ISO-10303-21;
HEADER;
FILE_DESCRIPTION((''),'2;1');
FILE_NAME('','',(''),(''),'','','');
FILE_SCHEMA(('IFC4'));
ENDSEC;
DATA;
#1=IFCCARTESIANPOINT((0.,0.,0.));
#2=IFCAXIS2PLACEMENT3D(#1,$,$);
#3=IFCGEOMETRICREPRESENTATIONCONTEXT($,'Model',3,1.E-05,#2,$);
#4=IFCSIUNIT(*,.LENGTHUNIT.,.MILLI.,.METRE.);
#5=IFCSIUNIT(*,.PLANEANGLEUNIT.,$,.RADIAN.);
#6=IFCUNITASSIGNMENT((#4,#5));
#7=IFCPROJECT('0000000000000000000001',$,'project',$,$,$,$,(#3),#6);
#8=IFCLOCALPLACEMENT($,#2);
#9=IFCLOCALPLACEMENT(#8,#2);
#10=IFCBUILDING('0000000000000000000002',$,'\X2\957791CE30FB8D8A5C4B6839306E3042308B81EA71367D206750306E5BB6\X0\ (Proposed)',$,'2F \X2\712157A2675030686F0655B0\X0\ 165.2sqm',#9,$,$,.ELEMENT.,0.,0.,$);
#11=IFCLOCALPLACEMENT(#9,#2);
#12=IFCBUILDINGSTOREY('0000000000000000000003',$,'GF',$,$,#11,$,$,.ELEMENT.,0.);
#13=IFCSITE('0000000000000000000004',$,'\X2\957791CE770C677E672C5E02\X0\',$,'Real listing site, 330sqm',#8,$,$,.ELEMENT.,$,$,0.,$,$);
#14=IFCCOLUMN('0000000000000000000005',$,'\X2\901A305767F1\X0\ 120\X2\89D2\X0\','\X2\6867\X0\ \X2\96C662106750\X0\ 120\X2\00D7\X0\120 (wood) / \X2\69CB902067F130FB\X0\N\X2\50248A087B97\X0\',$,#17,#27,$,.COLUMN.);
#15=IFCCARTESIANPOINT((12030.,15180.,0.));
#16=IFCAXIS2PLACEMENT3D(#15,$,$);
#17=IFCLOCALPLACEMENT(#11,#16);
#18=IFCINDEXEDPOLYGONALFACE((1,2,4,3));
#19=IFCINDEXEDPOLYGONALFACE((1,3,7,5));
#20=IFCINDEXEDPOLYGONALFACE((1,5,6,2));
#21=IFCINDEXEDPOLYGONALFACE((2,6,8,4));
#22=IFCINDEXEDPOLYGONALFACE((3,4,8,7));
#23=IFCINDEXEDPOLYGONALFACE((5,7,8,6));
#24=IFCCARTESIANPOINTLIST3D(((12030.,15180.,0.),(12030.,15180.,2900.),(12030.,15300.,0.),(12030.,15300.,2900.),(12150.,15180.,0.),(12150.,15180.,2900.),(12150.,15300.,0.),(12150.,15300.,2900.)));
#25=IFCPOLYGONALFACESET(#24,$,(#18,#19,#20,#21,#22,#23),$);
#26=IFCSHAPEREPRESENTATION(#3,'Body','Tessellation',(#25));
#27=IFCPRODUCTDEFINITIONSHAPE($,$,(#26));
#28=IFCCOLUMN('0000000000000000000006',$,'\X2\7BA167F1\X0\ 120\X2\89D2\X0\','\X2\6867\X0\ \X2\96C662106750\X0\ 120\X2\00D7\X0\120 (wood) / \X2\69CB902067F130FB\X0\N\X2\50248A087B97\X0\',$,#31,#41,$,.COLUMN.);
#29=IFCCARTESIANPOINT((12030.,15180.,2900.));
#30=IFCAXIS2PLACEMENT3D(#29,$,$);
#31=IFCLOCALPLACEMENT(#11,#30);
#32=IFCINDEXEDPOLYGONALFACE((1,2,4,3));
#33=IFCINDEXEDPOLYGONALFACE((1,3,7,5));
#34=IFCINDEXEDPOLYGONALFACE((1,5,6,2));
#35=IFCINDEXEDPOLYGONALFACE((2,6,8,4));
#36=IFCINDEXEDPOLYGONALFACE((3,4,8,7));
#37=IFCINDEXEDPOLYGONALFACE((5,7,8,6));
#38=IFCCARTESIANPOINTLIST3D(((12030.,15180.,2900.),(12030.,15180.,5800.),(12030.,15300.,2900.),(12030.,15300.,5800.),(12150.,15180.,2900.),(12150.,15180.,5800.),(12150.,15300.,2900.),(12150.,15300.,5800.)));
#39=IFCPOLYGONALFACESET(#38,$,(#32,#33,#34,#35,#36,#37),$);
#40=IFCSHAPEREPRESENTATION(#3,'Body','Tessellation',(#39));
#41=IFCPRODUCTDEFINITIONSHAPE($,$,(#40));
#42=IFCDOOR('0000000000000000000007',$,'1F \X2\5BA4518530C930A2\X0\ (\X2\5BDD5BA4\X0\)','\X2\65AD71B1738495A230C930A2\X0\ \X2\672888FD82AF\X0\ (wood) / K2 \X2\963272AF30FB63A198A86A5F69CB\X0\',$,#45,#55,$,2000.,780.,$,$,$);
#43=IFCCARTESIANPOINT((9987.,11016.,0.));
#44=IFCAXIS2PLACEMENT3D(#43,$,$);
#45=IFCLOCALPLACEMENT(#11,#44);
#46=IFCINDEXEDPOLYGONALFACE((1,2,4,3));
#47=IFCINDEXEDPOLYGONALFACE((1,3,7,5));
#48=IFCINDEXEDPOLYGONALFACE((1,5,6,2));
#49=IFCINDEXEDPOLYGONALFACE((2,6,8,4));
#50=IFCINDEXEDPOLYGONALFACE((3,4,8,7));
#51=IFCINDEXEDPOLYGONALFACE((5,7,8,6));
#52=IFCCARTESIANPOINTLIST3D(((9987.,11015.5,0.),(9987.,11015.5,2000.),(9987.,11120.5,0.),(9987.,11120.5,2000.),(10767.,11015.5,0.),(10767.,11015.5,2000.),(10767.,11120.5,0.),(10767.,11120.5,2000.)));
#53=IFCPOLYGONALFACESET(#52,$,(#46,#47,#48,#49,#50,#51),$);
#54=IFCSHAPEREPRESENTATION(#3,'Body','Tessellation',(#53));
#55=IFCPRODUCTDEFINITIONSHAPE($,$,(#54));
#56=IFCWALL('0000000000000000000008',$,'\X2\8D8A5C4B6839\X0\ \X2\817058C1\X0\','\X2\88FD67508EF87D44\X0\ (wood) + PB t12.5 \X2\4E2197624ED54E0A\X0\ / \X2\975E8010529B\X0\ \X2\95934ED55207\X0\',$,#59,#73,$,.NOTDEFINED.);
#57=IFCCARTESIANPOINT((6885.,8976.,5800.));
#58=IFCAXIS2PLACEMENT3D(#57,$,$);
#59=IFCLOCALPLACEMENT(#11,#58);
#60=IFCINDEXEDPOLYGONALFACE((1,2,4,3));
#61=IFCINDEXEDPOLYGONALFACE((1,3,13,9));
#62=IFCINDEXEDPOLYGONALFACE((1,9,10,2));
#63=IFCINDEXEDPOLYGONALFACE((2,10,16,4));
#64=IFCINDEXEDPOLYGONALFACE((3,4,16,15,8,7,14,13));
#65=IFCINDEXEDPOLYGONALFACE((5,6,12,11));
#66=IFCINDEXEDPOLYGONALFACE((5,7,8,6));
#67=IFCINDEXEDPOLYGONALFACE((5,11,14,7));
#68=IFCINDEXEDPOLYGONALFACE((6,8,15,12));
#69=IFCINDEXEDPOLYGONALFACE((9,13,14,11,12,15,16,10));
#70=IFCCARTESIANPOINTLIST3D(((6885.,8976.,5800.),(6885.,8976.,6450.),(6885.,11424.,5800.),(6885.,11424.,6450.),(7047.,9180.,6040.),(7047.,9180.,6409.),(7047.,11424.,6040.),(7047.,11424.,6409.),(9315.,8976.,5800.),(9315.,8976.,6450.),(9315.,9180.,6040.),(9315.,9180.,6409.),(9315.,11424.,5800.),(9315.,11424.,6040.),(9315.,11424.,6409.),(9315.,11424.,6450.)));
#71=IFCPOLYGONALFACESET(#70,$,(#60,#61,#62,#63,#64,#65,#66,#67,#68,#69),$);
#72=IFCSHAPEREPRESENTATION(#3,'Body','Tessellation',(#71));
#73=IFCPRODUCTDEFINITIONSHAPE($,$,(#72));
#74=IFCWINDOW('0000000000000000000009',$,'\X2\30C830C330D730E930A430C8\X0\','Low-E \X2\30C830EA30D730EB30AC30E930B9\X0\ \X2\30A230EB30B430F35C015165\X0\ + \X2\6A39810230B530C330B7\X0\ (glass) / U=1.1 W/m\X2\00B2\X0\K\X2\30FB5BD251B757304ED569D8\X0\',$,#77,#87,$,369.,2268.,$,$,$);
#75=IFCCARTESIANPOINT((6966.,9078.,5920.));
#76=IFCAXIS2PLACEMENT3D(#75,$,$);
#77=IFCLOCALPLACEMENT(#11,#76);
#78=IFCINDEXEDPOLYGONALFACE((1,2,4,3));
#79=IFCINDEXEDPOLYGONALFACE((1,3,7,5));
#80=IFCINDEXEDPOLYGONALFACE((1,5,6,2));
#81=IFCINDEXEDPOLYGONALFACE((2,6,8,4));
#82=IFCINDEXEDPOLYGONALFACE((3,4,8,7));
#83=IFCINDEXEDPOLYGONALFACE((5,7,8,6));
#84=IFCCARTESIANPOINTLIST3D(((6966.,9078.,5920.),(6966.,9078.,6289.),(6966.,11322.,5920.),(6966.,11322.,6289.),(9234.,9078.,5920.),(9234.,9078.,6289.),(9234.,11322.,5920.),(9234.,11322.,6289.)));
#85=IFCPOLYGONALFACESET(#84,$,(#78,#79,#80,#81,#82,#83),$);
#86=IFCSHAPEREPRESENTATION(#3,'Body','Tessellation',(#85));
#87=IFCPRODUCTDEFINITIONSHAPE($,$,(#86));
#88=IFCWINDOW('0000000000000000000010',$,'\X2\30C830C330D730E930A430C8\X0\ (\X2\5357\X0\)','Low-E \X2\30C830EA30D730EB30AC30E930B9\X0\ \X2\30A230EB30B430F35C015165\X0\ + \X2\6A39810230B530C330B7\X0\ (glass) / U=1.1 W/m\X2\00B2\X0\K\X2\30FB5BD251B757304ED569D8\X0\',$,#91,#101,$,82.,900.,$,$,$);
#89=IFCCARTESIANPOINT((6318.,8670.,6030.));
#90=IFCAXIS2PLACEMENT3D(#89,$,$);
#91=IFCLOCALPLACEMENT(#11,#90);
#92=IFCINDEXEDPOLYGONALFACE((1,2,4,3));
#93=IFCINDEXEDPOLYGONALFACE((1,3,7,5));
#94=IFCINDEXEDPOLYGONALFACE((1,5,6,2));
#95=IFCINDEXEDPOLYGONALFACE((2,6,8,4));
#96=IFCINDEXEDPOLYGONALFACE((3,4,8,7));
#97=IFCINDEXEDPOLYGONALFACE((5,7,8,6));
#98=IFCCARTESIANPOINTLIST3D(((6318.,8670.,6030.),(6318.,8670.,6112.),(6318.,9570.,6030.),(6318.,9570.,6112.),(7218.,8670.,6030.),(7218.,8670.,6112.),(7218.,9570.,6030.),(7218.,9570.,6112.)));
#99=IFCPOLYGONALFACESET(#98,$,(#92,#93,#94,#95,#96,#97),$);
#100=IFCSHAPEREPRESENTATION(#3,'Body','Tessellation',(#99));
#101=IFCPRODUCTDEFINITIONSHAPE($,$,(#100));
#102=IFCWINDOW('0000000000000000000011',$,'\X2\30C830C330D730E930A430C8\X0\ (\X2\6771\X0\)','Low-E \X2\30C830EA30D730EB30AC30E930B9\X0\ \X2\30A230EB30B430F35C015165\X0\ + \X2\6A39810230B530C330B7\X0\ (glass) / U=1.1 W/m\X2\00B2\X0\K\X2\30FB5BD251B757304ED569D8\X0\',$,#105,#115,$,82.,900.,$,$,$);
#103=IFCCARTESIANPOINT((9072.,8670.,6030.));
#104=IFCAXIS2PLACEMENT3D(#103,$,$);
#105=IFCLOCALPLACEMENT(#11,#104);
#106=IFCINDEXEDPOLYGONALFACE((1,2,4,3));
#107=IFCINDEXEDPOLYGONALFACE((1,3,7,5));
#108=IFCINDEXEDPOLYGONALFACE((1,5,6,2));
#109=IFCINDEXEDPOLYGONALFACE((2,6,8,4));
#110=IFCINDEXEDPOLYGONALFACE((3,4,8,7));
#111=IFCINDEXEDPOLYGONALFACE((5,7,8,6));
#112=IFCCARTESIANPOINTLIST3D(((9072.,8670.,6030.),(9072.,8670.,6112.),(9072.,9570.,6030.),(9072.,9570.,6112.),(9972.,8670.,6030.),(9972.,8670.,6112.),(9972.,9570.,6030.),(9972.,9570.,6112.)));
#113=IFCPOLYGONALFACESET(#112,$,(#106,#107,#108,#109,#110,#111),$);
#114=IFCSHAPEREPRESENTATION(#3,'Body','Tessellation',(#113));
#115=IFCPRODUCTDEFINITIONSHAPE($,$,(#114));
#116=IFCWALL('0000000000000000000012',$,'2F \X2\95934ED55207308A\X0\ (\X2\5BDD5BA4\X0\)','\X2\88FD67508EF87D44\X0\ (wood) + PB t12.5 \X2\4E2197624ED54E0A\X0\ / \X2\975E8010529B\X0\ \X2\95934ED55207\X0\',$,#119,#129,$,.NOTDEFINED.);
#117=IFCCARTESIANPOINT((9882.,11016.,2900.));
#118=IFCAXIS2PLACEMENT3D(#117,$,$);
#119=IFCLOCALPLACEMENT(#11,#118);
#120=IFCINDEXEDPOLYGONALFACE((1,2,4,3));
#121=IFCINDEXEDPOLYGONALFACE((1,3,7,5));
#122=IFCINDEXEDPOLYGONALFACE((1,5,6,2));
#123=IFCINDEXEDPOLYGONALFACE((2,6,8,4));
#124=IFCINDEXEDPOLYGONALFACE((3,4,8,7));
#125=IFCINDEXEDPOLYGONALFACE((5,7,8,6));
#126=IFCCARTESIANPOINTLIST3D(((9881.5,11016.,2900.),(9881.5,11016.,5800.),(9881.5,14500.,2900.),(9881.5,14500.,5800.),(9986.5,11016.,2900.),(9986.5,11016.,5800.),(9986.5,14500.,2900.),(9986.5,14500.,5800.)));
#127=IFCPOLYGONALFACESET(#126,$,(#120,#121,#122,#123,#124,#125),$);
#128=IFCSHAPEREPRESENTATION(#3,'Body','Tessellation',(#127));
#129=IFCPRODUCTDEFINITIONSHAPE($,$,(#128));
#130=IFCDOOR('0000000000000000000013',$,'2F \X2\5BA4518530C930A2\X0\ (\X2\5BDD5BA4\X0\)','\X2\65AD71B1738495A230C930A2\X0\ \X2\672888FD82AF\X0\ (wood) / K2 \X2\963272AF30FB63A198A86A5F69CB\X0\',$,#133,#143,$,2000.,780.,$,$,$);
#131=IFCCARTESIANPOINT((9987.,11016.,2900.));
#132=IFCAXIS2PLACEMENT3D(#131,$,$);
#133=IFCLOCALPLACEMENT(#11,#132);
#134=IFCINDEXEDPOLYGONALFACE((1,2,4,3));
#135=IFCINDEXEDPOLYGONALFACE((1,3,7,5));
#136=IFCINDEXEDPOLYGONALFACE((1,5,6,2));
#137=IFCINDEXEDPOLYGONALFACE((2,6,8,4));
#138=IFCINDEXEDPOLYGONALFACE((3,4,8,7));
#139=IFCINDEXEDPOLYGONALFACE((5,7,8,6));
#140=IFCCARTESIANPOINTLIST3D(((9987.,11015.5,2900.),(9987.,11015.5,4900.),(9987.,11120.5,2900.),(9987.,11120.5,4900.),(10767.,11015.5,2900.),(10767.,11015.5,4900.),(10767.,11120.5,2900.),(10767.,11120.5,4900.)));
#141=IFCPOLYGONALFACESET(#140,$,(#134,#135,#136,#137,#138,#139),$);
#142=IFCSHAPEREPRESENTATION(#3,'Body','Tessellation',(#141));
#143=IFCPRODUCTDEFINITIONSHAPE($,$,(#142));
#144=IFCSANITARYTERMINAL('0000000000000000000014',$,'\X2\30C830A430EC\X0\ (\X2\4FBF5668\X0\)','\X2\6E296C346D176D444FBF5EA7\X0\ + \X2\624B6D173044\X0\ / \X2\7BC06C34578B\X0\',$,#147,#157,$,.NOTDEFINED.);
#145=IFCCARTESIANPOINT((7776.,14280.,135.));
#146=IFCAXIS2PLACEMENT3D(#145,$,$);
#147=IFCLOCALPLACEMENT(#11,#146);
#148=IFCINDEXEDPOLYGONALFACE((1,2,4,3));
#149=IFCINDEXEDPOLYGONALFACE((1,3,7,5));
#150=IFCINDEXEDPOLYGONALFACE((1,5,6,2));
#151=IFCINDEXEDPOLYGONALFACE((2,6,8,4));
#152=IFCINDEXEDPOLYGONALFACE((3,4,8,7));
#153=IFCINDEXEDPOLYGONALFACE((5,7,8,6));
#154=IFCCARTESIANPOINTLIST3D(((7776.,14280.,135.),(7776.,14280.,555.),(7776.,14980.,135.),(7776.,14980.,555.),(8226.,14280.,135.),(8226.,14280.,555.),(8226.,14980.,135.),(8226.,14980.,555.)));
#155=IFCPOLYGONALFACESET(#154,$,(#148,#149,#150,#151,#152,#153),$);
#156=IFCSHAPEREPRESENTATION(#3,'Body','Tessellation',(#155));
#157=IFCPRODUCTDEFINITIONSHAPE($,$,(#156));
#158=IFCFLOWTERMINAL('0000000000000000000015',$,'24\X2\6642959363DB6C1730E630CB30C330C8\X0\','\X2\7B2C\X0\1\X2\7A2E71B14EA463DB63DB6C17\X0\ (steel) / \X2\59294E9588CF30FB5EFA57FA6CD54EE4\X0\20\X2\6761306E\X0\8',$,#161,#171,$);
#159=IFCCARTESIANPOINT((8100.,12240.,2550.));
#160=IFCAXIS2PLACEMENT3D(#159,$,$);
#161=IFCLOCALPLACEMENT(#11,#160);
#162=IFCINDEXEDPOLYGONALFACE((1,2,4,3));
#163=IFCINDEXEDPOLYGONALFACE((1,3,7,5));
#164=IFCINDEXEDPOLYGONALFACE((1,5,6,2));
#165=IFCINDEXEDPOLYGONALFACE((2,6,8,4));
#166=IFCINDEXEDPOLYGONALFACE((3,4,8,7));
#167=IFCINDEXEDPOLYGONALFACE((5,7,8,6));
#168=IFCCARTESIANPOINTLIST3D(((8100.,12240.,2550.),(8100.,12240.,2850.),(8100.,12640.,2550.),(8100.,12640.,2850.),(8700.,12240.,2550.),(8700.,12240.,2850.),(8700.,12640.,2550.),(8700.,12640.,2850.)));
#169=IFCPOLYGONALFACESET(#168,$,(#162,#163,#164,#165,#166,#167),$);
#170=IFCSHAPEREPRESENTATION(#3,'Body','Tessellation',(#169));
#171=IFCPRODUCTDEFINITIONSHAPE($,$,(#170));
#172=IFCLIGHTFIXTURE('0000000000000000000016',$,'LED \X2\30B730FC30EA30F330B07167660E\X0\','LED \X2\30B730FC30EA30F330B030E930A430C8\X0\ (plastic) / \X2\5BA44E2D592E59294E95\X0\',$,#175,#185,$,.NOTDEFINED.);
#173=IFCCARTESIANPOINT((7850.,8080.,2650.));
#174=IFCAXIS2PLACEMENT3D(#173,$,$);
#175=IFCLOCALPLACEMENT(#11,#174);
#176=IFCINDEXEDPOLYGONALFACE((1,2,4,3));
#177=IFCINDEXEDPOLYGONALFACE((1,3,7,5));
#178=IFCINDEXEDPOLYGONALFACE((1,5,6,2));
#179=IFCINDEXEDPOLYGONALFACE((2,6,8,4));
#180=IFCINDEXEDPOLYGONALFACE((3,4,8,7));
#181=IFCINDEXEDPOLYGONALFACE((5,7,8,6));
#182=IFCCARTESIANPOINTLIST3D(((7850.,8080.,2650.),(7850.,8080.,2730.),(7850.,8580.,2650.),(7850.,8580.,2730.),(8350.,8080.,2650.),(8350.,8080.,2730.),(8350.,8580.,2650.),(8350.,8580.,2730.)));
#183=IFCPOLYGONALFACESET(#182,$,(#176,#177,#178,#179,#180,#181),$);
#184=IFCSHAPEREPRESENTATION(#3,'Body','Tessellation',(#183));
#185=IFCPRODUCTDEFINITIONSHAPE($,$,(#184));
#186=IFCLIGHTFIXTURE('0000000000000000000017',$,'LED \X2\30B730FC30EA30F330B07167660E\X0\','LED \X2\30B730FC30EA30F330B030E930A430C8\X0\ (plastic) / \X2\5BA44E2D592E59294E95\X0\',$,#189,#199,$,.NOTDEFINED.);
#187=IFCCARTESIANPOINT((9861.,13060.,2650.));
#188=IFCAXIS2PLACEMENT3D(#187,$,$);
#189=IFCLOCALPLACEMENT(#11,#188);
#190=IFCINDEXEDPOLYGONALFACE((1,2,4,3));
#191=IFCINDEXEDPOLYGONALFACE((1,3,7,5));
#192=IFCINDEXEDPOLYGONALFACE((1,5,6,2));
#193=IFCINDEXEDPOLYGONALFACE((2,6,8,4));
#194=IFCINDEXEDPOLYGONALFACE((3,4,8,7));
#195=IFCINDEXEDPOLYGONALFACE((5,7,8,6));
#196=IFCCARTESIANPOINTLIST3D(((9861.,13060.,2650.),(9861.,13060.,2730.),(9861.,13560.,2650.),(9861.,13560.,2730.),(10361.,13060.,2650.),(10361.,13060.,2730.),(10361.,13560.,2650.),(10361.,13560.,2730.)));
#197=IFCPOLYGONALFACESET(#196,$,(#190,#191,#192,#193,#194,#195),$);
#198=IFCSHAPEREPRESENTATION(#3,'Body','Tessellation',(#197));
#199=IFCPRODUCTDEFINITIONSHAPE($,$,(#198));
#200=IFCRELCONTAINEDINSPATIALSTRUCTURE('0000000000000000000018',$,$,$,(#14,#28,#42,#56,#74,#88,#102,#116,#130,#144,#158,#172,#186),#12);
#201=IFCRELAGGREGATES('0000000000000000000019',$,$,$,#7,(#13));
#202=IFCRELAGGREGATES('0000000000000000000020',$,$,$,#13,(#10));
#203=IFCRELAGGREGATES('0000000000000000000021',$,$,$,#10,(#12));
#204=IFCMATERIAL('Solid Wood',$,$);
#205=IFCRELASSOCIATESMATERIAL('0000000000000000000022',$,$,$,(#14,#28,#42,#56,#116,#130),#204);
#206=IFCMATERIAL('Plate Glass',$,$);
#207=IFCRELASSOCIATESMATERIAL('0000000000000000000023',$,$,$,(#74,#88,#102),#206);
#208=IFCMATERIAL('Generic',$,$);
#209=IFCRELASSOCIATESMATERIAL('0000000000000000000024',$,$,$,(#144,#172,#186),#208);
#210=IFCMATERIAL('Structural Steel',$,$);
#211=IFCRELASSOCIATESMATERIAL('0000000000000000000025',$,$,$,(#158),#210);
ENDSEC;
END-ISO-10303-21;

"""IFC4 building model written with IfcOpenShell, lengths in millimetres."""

from ifc_helpers import new_model, si_unit, frame, frame_2d, origin, place, context, project, spatial, rectangle, extrude, material, element, fill, save


model = new_model("IFC4")

# Units and contexts
model_context = context("Model", 3, precision=1e-05, world=origin())
ifc_project = project(units=[si_unit("LENGTHUNIT", "METRE", prefix="MILLI"), si_unit("PLANEANGLEUNIT", "RADIAN")], contexts=[model_context])

# Site, building, storey
site_placement = place(None, origin())
site = spatial("IfcSite", under=ifc_project, at=site_placement, Name="長野県松本市", ObjectType="Real listing site, 330sqm", CompositionType="ELEMENT", RefElevation=0.0)
building_placement = place(site_placement, origin())
building = spatial("IfcBuilding", under=site, at=building_placement, Name="長野・越屋根のある自然素材の家 (Proposed)", ObjectType="2F 無垢材と漆喰 165.2sqm", CompositionType="ELEMENT", ElevationOfRefHeight=0.0, ElevationOfTerrain=0.0)
storey_placement = place(building_placement, origin())
storey = spatial("IfcBuildingStorey", under=building, at=storey_placement, Name="GF", CompositionType="ELEMENT", Elevation=0.0)

# Columns
ifc_material_1 = material(Name="Solid Wood")
column_1_placement = place(storey_placement, frame((12030.0, 15180.0, 0.0)))
element("IfcColumn", 1, at=column_1_placement, inside=storey, material=ifc_material_1, Name="通し柱 120角", Description="桧 集成材 120×120 (wood) / 構造柱・N値計算", PredefinedType="COLUMN", context=model_context, shape_type="SweptSolid", body=[
    extrude(rectangle(XDim=120.0, YDim=120.0, at=frame_2d((60.0, 60.0))), frame((12030.0, 15180.0, 0.0)), (0.0, 0.0, 1.0), 2900.0),
])
column_2_placement = place(storey_placement, frame((12030.0, 15180.0, 2900.0)))
element("IfcColumn", 2, at=column_2_placement, inside=storey, material=ifc_material_1, Name="管柱 120角", Description="桧 集成材 120×120 (wood) / 構造柱・N値計算", PredefinedType="COLUMN", context=model_context, shape_type="SweptSolid", body=[
    extrude(rectangle(XDim=120.0, YDim=120.0, at=frame_2d((60.0, 60.0))), frame((12030.0, 15180.0, 2900.0)), (0.0, 0.0, 1.0), 2900.0),
])

# Door
door_1_placement = place(storey_placement, frame((9987.0, 11016.0, 0.0)))
element("IfcDoor", 3, at=door_1_placement, inside=storey, material=ifc_material_1, Name="1F 室内ドア (寝室)", Description="断熱玄関ドア 木製芯 (wood) / K2 防犯・採風機構", OverallHeight=2000.0, OverallWidth=780.0, context=model_context, shape_type="SweptSolid", body=[
    extrude(rectangle(XDim=780.0, YDim=105.0, at=frame_2d((390.0, 52.0))), frame((9987.0, 11016.0, 0.0)), (0.0, 0.0, 1.0), 2000.0),
])

# Wall, openings, windows
wall_1_placement = place(storey_placement, frame((6885.0, 8976.0, 5800.0)))
wall_1 = element("IfcWall", 4, at=wall_1_placement, inside=storey, material=ifc_material_1, Name="越屋根 腰壁", Description="製材軸組 (wood) + PB t12.5 両面仕上 / 非耐力 間仕切", PredefinedType="NOTDEFINED", context=model_context, shape_type="SweptSolid", body=[
    extrude(rectangle(XDim=2430.0, YDim=2448.0, at=frame_2d((1215.0, 1224.0))), frame((6885.0, 8976.0, 5800.0)), (0.0, 0.0, 1.0), 650.0),
])
opening_1_placement = place(storey_placement, frame((6966.0, 9078.0, 5920.0)))
opening_1 = element("IfcOpeningElement", 5, at=opening_1_placement, cuts=wall_1, PredefinedType="NOTDEFINED", context=model_context, shape_type="SweptSolid", body=[
    extrude(rectangle(XDim=2268.0, YDim=2244.0, at=frame_2d((1134.0, 1122.0))), frame((6966.0, 9078.0, 5920.0)), (0.0, 0.0, 1.0), 369.0),
])
opening_2_placement = place(storey_placement, frame((6318.0, 8670.0, 6030.0)))
opening_2 = element("IfcOpeningElement", 6, at=opening_2_placement, cuts=wall_1, PredefinedType="NOTDEFINED", context=model_context, shape_type="SweptSolid", body=[
    extrude(rectangle(XDim=900.0, YDim=900.0, at=frame_2d((450.0, 450.0))), frame((6318.0, 8670.0, 6030.0)), (0.0, 0.0, 1.0), 82.0),
])
opening_3_placement = place(storey_placement, frame((9072.0, 8670.0, 6030.0)))
opening_3 = element("IfcOpeningElement", 7, at=opening_3_placement, cuts=wall_1, PredefinedType="NOTDEFINED", context=model_context, shape_type="SweptSolid", body=[
    extrude(rectangle(XDim=900.0, YDim=900.0, at=frame_2d((450.0, 450.0))), frame((9072.0, 8670.0, 6030.0)), (0.0, 0.0, 1.0), 82.0),
])
ifc_material_2 = material(Name="Plate Glass")
window_1_placement = place(storey_placement, frame((6966.0, 9078.0, 5920.0)))
window_1 = element("IfcWindow", 8, at=window_1_placement, inside=storey, material=ifc_material_2, Name="トップライト", Description="Low-E トリプルガラス アルゴン封入 + 樹脂サッシ (glass) / U=1.1 W/m²K・寒冷地仕様", OverallHeight=369.0, OverallWidth=2268.0, context=model_context, shape_type="SweptSolid", body=[
    extrude(rectangle(XDim=2268.0, YDim=2244.0, at=frame_2d((1134.0, 1122.0))), frame((6966.0, 9078.0, 5920.0)), (0.0, 0.0, 1.0), 369.0),
])
fill(opening_1, window_1)
window_2_placement = place(storey_placement, frame((6318.0, 8670.0, 6030.0)))
window_2 = element("IfcWindow", 9, at=window_2_placement, inside=storey, material=ifc_material_2, Name="トップライト (南)", Description="Low-E トリプルガラス アルゴン封入 + 樹脂サッシ (glass) / U=1.1 W/m²K・寒冷地仕様", OverallHeight=82.0, OverallWidth=900.0, context=model_context, shape_type="SweptSolid", body=[
    extrude(rectangle(XDim=900.0, YDim=900.0, at=frame_2d((450.0, 450.0))), frame((6318.0, 8670.0, 6030.0)), (0.0, 0.0, 1.0), 82.0),
])
fill(opening_2, window_2)
window_3_placement = place(storey_placement, frame((9072.0, 8670.0, 6030.0)))
window_3 = element("IfcWindow", 10, at=window_3_placement, inside=storey, material=ifc_material_2, Name="トップライト (東)", Description="Low-E トリプルガラス アルゴン封入 + 樹脂サッシ (glass) / U=1.1 W/m²K・寒冷地仕様", OverallHeight=82.0, OverallWidth=900.0, context=model_context, shape_type="SweptSolid", body=[
    extrude(rectangle(XDim=900.0, YDim=900.0, at=frame_2d((450.0, 450.0))), frame((9072.0, 8670.0, 6030.0)), (0.0, 0.0, 1.0), 82.0),
])
fill(opening_3, window_3)

# Wall
wall_2_placement = place(storey_placement, frame((9882.0, 11016.0, 2900.0)))
element("IfcWall", 11, at=wall_2_placement, inside=storey, material=ifc_material_1, Name="2F 間仕切り (寝室)", Description="製材軸組 (wood) + PB t12.5 両面仕上 / 非耐力 間仕切", PredefinedType="NOTDEFINED", context=model_context, shape_type="SweptSolid", body=[
    extrude(rectangle(XDim=105.0, YDim=3484.0, at=frame_2d((52.0, 1742.0))), frame((9882.0, 11016.0, 2900.0)), (0.0, 0.0, 1.0), 2900.0),
])

# Door
door_2_placement = place(storey_placement, frame((9987.0, 11016.0, 2900.0)))
element("IfcDoor", 12, at=door_2_placement, inside=storey, material=ifc_material_1, Name="2F 室内ドア (寝室)", Description="断熱玄関ドア 木製芯 (wood) / K2 防犯・採風機構", OverallHeight=2000.0, OverallWidth=780.0, context=model_context, shape_type="SweptSolid", body=[
    extrude(rectangle(XDim=780.0, YDim=105.0, at=frame_2d((390.0, 52.0))), frame((9987.0, 11016.0, 2900.0)), (0.0, 0.0, 1.0), 2000.0),
])

# Sanitary terminal
ifc_material_3 = material(Name="Generic")
sanitary_terminal_placement = place(storey_placement, frame((7776.0, 14280.0, 135.0)))
element("IfcSanitaryTerminal", 13, at=sanitary_terminal_placement, inside=storey, material=ifc_material_3, Name="トイレ (便器)", Description="温水洗浄便座 + 手洗い / 節水型", PredefinedType="NOTDEFINED", context=model_context, shape_type="SweptSolid", body=[
    extrude(rectangle(XDim=450.0, YDim=700.0, at=frame_2d((225.0, 350.0))), frame((7776.0, 14280.0, 135.0)), (0.0, 0.0, 1.0), 420.0),
])

# Flow terminal
ifc_material_4 = material(Name="Structural Steel")
flow_terminal_placement = place(storey_placement, frame((8100.0, 12240.0, 2550.0)))
element("IfcFlowTerminal", 14, at=flow_terminal_placement, inside=storey, material=ifc_material_4, Name="24時間換気ユニット", Description="第1種熱交換換気 (steel) / 天井裏・建基法令20条の8", context=model_context, shape_type="SweptSolid", body=[
    extrude(rectangle(XDim=600.0, YDim=400.0, at=frame_2d((300.0, 200.0))), frame((8100.0, 12240.0, 2550.0)), (0.0, 0.0, 1.0), 300.0),
])

# Light fixtures
light_fixture_1_placement = place(storey_placement, frame((7850.0, 8080.0, 2650.0)))
element("IfcLightFixture", 15, at=light_fixture_1_placement, inside=storey, material=ifc_material_3, Name="LED シーリング照明", Description="LED シーリングライト (plastic) / 室中央天井", PredefinedType="NOTDEFINED", context=model_context, shape_type="SweptSolid", body=[
    extrude(rectangle(XDim=500.0, YDim=500.0, at=frame_2d((250.0, 250.0))), frame((7850.0, 8080.0, 2650.0)), (0.0, 0.0, 1.0), 80.0),
])
light_fixture_2_placement = place(storey_placement, frame((9861.0, 13060.0, 2650.0)))
element("IfcLightFixture", 16, at=light_fixture_2_placement, inside=storey, material=ifc_material_3, Name="LED シーリング照明", Description="LED シーリングライト (plastic) / 室中央天井", PredefinedType="NOTDEFINED", context=model_context, shape_type="SweptSolid", body=[
    extrude(rectangle(XDim=500.0, YDim=500.0, at=frame_2d((250.0, 250.0))), frame((9861.0, 13060.0, 2650.0)), (0.0, 0.0, 1.0), 80.0),
])

save(model, "model.ifc")
